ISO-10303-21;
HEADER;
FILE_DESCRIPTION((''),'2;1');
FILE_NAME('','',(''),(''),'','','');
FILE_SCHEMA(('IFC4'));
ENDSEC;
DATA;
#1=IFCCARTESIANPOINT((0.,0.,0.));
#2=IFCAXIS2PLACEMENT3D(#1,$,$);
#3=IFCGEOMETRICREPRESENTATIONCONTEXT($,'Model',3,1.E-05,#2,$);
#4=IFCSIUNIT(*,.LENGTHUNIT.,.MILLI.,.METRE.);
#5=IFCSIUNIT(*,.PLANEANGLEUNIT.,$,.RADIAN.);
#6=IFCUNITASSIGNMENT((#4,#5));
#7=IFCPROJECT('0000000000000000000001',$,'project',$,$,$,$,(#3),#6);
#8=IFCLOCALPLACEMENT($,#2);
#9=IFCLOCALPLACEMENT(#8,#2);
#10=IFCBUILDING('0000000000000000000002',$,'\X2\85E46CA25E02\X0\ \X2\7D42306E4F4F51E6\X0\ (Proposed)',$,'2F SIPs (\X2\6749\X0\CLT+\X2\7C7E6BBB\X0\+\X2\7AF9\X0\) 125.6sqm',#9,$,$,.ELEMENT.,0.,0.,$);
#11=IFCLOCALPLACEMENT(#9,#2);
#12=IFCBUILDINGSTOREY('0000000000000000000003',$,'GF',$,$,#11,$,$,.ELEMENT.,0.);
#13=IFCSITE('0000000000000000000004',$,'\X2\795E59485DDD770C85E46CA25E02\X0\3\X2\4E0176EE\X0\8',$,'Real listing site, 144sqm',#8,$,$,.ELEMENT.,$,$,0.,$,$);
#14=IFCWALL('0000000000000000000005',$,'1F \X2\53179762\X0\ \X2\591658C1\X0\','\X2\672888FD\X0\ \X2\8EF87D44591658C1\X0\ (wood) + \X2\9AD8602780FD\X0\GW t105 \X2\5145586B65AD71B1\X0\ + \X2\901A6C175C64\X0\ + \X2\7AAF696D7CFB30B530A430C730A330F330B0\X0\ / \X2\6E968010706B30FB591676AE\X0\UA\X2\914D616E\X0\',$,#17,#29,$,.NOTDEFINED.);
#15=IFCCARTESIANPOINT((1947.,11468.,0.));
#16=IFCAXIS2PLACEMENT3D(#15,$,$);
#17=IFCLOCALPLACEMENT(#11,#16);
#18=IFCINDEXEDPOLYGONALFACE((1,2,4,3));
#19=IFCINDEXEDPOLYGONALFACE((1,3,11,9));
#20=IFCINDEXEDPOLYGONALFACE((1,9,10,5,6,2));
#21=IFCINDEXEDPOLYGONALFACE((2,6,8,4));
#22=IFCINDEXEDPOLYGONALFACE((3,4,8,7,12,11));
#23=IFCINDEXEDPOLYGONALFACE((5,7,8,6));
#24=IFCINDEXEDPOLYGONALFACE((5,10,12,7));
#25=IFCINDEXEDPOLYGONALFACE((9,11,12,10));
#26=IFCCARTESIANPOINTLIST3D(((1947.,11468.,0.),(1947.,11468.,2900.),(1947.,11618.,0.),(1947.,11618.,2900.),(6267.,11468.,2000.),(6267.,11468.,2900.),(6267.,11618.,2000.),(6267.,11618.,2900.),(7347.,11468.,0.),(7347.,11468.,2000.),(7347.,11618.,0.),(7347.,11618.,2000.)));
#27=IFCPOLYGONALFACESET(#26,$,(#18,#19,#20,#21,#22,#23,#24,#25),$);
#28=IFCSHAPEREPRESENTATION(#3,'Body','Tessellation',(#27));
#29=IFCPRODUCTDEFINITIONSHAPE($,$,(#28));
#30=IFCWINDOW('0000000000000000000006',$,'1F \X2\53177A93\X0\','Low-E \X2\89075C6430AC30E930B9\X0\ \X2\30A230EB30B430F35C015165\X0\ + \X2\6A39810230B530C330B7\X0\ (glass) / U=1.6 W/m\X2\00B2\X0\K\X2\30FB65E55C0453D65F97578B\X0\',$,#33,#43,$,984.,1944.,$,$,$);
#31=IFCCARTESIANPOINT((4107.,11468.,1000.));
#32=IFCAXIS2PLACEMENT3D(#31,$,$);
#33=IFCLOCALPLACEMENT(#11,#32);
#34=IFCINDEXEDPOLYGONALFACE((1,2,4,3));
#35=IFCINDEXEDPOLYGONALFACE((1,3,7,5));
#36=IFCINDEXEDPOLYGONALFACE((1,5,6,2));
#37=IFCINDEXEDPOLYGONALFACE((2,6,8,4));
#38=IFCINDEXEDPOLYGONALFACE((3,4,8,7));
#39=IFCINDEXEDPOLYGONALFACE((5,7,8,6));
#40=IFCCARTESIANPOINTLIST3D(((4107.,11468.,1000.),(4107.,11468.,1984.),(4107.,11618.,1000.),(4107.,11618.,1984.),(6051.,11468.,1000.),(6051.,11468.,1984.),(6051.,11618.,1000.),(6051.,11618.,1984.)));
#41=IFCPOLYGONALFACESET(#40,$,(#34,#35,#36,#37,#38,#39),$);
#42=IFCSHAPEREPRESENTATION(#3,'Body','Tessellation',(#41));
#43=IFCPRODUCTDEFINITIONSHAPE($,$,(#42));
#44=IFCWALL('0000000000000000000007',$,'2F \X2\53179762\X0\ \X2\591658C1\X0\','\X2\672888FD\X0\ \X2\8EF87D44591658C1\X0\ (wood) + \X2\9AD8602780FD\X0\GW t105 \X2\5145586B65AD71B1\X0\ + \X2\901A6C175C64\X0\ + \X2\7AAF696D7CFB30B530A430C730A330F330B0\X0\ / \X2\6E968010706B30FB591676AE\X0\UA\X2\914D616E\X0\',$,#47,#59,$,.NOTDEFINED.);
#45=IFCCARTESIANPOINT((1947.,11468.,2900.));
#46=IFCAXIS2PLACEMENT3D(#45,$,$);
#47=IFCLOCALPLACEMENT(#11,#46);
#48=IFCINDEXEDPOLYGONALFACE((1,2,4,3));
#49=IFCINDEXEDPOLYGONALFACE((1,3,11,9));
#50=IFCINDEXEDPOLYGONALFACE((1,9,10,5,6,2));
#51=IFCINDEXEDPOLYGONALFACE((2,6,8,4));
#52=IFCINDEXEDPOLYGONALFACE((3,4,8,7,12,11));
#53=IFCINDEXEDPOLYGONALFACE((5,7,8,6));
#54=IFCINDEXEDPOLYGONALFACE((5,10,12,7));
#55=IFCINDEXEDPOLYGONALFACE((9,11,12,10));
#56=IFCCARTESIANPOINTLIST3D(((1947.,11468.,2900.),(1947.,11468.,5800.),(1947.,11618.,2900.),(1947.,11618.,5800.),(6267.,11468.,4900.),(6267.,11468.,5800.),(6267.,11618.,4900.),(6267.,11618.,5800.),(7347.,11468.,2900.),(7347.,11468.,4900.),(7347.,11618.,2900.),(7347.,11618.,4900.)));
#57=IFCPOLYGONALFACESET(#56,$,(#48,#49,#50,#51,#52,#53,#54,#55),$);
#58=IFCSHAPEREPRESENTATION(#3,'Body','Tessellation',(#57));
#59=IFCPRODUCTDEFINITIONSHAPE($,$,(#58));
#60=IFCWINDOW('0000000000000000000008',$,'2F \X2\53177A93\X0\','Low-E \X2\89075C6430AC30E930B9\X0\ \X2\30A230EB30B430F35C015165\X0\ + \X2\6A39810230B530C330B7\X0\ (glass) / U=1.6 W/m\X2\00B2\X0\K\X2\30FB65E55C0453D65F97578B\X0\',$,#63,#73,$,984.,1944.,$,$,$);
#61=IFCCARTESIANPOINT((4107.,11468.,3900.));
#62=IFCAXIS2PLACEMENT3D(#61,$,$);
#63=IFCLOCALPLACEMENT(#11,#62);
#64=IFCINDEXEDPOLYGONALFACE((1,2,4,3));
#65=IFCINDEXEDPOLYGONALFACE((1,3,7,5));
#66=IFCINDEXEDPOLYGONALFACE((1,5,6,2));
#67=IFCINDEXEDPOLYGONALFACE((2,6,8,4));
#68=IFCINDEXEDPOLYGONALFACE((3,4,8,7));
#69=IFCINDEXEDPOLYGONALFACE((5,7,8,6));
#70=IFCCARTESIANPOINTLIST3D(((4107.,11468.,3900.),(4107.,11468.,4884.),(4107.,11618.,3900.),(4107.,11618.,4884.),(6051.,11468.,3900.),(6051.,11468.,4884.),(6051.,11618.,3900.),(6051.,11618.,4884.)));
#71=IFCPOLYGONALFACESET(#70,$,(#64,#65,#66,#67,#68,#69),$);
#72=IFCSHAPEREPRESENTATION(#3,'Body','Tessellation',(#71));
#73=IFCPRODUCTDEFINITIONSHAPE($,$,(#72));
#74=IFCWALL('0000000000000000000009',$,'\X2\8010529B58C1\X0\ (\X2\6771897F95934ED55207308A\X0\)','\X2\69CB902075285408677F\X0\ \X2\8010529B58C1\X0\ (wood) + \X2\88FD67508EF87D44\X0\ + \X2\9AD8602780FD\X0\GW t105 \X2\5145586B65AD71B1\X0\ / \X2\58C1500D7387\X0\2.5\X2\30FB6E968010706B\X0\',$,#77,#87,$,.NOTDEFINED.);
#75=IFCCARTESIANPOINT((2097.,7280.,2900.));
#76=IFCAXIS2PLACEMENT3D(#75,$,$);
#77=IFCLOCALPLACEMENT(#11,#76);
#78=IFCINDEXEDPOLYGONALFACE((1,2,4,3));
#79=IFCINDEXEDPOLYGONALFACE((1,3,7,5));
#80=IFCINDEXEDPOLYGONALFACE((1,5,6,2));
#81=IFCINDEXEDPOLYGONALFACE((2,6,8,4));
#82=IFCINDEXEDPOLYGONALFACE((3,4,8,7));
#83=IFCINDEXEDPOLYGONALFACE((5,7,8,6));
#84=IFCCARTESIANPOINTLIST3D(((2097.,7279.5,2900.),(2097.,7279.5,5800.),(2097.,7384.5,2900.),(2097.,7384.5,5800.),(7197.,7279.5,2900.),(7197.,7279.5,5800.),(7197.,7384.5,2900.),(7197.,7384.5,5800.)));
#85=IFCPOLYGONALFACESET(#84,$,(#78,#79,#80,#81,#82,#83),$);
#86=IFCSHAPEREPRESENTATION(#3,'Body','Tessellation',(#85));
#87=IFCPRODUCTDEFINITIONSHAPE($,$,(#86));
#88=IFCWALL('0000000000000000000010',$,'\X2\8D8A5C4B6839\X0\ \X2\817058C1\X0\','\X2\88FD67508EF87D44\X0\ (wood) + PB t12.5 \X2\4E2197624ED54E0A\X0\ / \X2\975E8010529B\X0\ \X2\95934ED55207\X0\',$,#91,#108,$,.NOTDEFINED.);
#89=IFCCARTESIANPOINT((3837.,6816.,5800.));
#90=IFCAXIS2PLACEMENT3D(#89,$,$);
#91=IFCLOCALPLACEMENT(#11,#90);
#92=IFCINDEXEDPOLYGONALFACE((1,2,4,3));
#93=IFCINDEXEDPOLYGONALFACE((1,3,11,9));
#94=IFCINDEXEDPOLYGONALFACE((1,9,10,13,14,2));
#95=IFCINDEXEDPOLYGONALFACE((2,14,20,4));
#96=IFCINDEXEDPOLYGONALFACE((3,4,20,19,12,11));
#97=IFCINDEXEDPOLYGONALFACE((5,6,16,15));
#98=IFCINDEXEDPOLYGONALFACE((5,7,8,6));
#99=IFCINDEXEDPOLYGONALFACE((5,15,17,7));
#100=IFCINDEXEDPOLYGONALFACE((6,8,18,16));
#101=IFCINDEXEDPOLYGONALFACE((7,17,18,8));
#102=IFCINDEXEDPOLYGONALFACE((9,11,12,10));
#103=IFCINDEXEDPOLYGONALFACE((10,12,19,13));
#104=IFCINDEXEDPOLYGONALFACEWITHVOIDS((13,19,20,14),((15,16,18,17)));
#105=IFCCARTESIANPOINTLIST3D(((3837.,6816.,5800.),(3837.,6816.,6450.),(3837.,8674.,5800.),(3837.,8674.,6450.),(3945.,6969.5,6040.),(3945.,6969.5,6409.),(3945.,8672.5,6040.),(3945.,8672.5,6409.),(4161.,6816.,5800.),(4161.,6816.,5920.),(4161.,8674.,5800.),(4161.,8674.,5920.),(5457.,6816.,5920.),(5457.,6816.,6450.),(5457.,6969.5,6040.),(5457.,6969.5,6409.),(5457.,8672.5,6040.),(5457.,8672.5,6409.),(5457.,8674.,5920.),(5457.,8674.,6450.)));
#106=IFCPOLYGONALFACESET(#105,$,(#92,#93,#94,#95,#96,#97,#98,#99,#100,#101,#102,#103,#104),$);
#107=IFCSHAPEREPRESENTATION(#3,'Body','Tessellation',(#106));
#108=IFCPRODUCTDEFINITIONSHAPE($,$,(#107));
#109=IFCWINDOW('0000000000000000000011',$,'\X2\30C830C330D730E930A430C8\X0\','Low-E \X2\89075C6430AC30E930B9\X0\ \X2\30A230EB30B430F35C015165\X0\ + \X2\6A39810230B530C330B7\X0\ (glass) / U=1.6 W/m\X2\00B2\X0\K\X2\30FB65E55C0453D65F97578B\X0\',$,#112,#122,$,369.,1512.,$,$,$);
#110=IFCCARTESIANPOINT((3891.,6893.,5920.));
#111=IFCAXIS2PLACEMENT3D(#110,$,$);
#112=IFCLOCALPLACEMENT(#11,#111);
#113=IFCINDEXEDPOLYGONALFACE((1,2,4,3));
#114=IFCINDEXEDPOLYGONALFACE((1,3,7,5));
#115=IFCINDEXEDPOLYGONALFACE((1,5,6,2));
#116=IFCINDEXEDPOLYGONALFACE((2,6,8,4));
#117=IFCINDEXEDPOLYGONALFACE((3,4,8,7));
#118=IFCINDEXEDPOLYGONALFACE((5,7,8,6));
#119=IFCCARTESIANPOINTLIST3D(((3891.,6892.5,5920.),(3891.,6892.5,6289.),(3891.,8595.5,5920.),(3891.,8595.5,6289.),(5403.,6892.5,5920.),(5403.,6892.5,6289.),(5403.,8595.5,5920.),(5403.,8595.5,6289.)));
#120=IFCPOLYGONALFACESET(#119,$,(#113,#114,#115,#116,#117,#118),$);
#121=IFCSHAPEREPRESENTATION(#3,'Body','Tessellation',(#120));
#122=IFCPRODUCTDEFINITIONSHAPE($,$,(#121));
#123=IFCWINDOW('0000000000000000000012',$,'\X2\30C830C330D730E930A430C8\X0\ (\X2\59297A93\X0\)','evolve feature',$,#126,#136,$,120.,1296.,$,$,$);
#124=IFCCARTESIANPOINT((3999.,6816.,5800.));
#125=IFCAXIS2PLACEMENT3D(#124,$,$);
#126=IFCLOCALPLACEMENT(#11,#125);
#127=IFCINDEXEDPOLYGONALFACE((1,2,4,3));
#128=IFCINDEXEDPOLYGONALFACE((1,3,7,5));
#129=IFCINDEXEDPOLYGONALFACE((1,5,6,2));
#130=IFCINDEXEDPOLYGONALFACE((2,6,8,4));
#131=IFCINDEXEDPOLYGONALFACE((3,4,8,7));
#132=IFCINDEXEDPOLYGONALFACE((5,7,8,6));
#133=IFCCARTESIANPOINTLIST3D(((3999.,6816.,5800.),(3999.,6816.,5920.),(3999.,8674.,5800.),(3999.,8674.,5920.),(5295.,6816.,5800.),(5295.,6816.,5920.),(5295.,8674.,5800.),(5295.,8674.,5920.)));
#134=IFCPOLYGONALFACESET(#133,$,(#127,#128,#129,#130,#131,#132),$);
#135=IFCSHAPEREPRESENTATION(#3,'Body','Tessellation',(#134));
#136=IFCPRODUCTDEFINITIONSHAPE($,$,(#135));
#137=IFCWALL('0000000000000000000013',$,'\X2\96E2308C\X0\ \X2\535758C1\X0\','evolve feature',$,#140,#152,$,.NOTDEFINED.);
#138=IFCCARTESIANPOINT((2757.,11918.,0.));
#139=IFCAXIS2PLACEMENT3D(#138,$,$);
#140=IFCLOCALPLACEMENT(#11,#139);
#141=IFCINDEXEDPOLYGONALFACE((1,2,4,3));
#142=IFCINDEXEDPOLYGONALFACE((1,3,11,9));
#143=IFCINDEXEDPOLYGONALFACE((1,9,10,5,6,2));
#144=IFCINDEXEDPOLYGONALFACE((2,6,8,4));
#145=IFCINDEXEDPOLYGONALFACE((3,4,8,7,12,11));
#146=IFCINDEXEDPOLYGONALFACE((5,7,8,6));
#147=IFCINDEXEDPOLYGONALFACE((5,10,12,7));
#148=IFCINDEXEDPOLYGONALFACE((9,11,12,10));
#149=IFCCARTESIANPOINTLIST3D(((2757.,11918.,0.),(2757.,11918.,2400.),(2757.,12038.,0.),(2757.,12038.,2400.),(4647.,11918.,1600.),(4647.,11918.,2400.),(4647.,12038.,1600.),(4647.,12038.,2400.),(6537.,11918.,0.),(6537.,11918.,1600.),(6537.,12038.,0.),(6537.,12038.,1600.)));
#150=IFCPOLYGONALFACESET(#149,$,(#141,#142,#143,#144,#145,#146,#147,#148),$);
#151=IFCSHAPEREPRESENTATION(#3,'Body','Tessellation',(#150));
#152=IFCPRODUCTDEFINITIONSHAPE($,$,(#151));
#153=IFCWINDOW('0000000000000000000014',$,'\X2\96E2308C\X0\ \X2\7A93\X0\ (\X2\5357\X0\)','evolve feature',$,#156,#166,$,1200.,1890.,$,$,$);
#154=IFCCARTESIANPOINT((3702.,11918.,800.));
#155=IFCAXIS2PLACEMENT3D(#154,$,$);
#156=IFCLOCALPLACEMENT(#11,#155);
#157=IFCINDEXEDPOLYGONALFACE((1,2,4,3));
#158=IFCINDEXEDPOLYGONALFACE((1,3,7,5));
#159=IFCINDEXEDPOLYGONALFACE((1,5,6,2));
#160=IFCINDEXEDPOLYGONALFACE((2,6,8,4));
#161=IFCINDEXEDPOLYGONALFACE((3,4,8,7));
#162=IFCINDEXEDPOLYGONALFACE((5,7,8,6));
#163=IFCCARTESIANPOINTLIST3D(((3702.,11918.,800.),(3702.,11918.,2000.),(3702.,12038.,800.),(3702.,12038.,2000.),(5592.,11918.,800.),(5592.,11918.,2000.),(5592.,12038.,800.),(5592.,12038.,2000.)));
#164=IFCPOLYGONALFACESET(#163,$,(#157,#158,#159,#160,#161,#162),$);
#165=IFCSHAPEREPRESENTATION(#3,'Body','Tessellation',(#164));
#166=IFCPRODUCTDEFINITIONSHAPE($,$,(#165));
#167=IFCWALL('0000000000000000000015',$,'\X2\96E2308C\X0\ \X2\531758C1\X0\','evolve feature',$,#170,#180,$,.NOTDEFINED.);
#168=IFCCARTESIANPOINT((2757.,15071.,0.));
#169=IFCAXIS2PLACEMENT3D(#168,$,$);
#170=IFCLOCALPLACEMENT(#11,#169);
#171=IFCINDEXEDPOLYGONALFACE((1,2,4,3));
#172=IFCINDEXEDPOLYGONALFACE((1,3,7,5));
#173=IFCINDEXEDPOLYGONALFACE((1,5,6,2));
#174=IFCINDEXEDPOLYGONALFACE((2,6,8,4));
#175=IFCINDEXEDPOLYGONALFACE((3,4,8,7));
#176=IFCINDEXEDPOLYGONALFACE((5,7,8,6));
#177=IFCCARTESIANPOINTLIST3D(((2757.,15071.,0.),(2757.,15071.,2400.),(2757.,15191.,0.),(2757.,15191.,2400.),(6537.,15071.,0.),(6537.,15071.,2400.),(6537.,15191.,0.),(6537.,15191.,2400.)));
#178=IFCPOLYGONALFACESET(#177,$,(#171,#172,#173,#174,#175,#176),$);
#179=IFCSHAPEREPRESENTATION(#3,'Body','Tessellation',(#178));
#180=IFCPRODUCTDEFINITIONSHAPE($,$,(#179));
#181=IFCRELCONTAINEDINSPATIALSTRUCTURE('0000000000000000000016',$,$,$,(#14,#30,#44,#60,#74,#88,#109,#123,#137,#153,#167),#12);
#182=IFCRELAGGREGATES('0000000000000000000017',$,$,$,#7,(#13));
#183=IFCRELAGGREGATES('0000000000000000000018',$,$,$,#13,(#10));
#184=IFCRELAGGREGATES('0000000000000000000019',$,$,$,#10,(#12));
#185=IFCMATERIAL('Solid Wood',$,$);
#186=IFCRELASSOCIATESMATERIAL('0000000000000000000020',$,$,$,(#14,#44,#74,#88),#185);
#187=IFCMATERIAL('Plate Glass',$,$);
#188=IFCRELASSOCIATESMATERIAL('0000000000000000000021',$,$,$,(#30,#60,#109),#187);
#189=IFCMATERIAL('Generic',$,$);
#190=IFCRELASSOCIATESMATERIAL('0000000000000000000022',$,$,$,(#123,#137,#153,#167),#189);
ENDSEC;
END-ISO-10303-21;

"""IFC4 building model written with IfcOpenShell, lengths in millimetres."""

from ifc_helpers import new_model, si_unit, frame, frame_2d, origin, place, context, project, spatial, rectangle, extrude, material, element, fill, save


model = new_model("IFC4")

# Units and contexts
model_context = context("Model", 3, precision=1e-05, world=origin())
ifc_project = project(units=[si_unit("LENGTHUNIT", "METRE", prefix="MILLI"), si_unit("PLANEANGLEUNIT", "RADIAN")], contexts=[model_context])

# Site, building, storey
site_placement = place(None, origin())
site = spatial("IfcSite", under=ifc_project, at=site_placement, Name="神奈川県藤沢市3丁目8", ObjectType="Real listing site, 144sqm", CompositionType="ELEMENT", RefElevation=0.0)
building_placement = place(site_placement, origin())
building = spatial("IfcBuilding", under=site, at=building_placement, Name="藤沢市 終の住処 (Proposed)", ObjectType="2F SIPs (杉CLT+籾殻+竹) 125.6sqm", CompositionType="ELEMENT", ElevationOfRefHeight=0.0, ElevationOfTerrain=0.0)
storey_placement = place(building_placement, origin())
storey = spatial("IfcBuildingStorey", under=building, at=storey_placement, Name="GF", CompositionType="ELEMENT", Elevation=0.0)

# Shared definitions
ifc_material_1 = material(Name="Generic")

# Wall, opening, window
ifc_material_2 = material(Name="Solid Wood")
wall_1_placement = place(storey_placement, frame((1947.0, 11468.0, 0.0)))
wall_1 = element("IfcWall", 1, at=wall_1_placement, inside=storey, material=ifc_material_2, Name="1F 北面 外壁", Description="木製 軸組外壁 (wood) + 高性能GW t105 充填断熱 + 通気層 + 窯業系サイディング / 準耐火・外皮UA配慮", PredefinedType="NOTDEFINED", context=model_context, shape_type="SweptSolid", body=[
    extrude(rectangle(XDim=5400.0, YDim=150.0, at=frame_2d((2700.0, 75.0))), frame((1947.0, 11468.0, 0.0)), (0.0, 0.0, 1.0), 2900.0),
])
opening_1_placement = place(storey_placement, frame((4107.0, 11468.0, 1000.0)))
opening_1 = element("IfcOpeningElement", 2, at=opening_1_placement, cuts=wall_1, PredefinedType="NOTDEFINED", context=model_context, shape_type="SweptSolid", body=[
    extrude(rectangle(XDim=1944.0, YDim=150.0, at=frame_2d((972.0, 75.0))), frame((4107.0, 11468.0, 1000.0)), (0.0, 0.0, 1.0), 984.0),
])
ifc_material_3 = material(Name="Plate Glass")
window_1_placement = place(storey_placement, frame((4107.0, 11468.0, 1000.0)))
window_1 = element("IfcWindow", 3, at=window_1_placement, inside=storey, material=ifc_material_3, Name="1F 北窓", Description="Low-E 複層ガラス アルゴン封入 + 樹脂サッシ (glass) / U=1.6 W/m²K・日射取得型", OverallHeight=984.0, OverallWidth=1944.0, context=model_context, shape_type="SweptSolid", body=[
    extrude(rectangle(XDim=1944.0, YDim=150.0, at=frame_2d((972.0, 75.0))), frame((4107.0, 11468.0, 1000.0)), (0.0, 0.0, 1.0), 984.0),
])
fill(opening_1, window_1)

# Wall, opening, window
wall_2_placement = place(storey_placement, frame((1947.0, 11468.0, 2900.0)))
wall_2 = element("IfcWall", 4, at=wall_2_placement, inside=storey, material=ifc_material_2, Name="2F 北面 外壁", Description="木製 軸組外壁 (wood) + 高性能GW t105 充填断熱 + 通気層 + 窯業系サイディング / 準耐火・外皮UA配慮", PredefinedType="NOTDEFINED", context=model_context, shape_type="SweptSolid", body=[
    extrude(rectangle(XDim=5400.0, YDim=150.0, at=frame_2d((2700.0, 75.0))), frame((1947.0, 11468.0, 2900.0)), (0.0, 0.0, 1.0), 2900.0),
])
opening_2_placement = place(storey_placement, frame((4107.0, 11468.0, 3900.0)))
opening_2 = element("IfcOpeningElement", 5, at=opening_2_placement, cuts=wall_2, PredefinedType="NOTDEFINED", context=model_context, shape_type="SweptSolid", body=[
    extrude(rectangle(XDim=1944.0, YDim=150.0, at=frame_2d((972.0, 75.0))), frame((4107.0, 11468.0, 3900.0)), (0.0, 0.0, 1.0), 984.0),
])
window_2_placement = place(storey_placement, frame((4107.0, 11468.0, 3900.0)))
window_2 = element("IfcWindow", 6, at=window_2_placement, inside=storey, material=ifc_material_3, Name="2F 北窓", Description="Low-E 複層ガラス アルゴン封入 + 樹脂サッシ (glass) / U=1.6 W/m²K・日射取得型", OverallHeight=984.0, OverallWidth=1944.0, context=model_context, shape_type="SweptSolid", body=[
    extrude(rectangle(XDim=1944.0, YDim=150.0, at=frame_2d((972.0, 75.0))), frame((4107.0, 11468.0, 3900.0)), (0.0, 0.0, 1.0), 984.0),
])
fill(opening_2, window_2)

# Wall
wall_3_placement = place(storey_placement, frame((2097.0, 7280.0, 2900.0)))
element("IfcWall", 7, at=wall_3_placement, inside=storey, material=ifc_material_2, Name="耐力壁 (東西間仕切り)", Description="構造用合板 耐力壁 (wood) + 製材軸組 + 高性能GW t105 充填断熱 / 壁倍率2.5・準耐火", PredefinedType="NOTDEFINED", context=model_context, shape_type="SweptSolid", body=[
    extrude(rectangle(XDim=5100.0, YDim=105.0, at=frame_2d((2550.0, 52.0))), frame((2097.0, 7280.0, 2900.0)), (0.0, 0.0, 1.0), 2900.0),
])

# Wall, openings, windows
wall_4_placement = place(storey_placement, frame((3837.0, 6816.0, 5800.0)))
wall_4 = element("IfcWall", 8, at=wall_4_placement, inside=storey, material=ifc_material_2, Name="越屋根 腰壁", Description="製材軸組 (wood) + PB t12.5 両面仕上 / 非耐力 間仕切", PredefinedType="NOTDEFINED", context=model_context, shape_type="SweptSolid", body=[
    extrude(rectangle(XDim=1620.0, YDim=1858.0, at=frame_2d((810.0, 929.0))), frame((3837.0, 6816.0, 5800.0)), (0.0, 0.0, 1.0), 650.0),
])
opening_3_placement = place(storey_placement, frame((3891.0, 6893.0, 5920.0)))
opening_3 = element("IfcOpeningElement", 9, at=opening_3_placement, cuts=wall_4, PredefinedType="NOTDEFINED", context=model_context, shape_type="SweptSolid", body=[
    extrude(rectangle(XDim=1512.0, YDim=1703.0, at=frame_2d((756.0, 851.0))), frame((3891.0, 6893.0, 5920.0)), (0.0, 0.0, 1.0), 369.0),
])
opening_4_placement = place(storey_placement, frame((3999.0, 6816.0, 5800.0)))
opening_4 = element("IfcOpeningElement", 10, at=opening_4_placement, cuts=wall_4, PredefinedType="NOTDEFINED", context=model_context, shape_type="SweptSolid", body=[
    extrude(rectangle(XDim=1296.0, YDim=1858.0, at=frame_2d((648.0, 929.0))), frame((3999.0, 6816.0, 5800.0)), (0.0, 0.0, 1.0), 120.0),
])
window_3_placement = place(storey_placement, frame((3891.0, 6893.0, 5920.0)))
window_3 = element("IfcWindow", 11, at=window_3_placement, inside=storey, material=ifc_material_3, Name="トップライト", Description="Low-E 複層ガラス アルゴン封入 + 樹脂サッシ (glass) / U=1.6 W/m²K・日射取得型", OverallHeight=369.0, OverallWidth=1512.0, context=model_context, shape_type="SweptSolid", body=[
    extrude(rectangle(XDim=1512.0, YDim=1703.0, at=frame_2d((756.0, 851.0))), frame((3891.0, 6893.0, 5920.0)), (0.0, 0.0, 1.0), 369.0),
])
fill(opening_3, window_3)
window_4_placement = place(storey_placement, frame((3999.0, 6816.0, 5800.0)))
window_4 = element("IfcWindow", 12, at=window_4_placement, inside=storey, material=ifc_material_1, Name="トップライト (天窓)", Description="evolve feature", OverallHeight=120.0, OverallWidth=1296.0, context=model_context, shape_type="SweptSolid", body=[
    extrude(rectangle(XDim=1296.0, YDim=1858.0, at=frame_2d((648.0, 929.0))), frame((3999.0, 6816.0, 5800.0)), (0.0, 0.0, 1.0), 120.0),
])
fill(opening_4, window_4)

# Wall, opening, window
wall_5_placement = place(storey_placement, frame((2757.0, 11918.0, 0.0)))
wall_5 = element("IfcWall", 13, at=wall_5_placement, inside=storey, material=ifc_material_1, Name="離れ 南壁", Description="evolve feature", PredefinedType="NOTDEFINED", context=model_context, shape_type="SweptSolid", body=[
    extrude(rectangle(XDim=3780.0, YDim=120.0, at=frame_2d((1890.0, 60.0))), frame((2757.0, 11918.0, 0.0)), (0.0, 0.0, 1.0), 2400.0),
])
opening_5_placement = place(storey_placement, frame((3702.0, 11918.0, 800.0)))
opening_5 = element("IfcOpeningElement", 14, at=opening_5_placement, cuts=wall_5, PredefinedType="NOTDEFINED", context=model_context, shape_type="SweptSolid", body=[
    extrude(rectangle(XDim=1890.0, YDim=120.0, at=frame_2d((945.0, 60.0))), frame((3702.0, 11918.0, 800.0)), (0.0, 0.0, 1.0), 1200.0),
])
window_5_placement = place(storey_placement, frame((3702.0, 11918.0, 800.0)))
window_5 = element("IfcWindow", 15, at=window_5_placement, inside=storey, material=ifc_material_1, Name="離れ 窓 (南)", Description="evolve feature", OverallHeight=1200.0, OverallWidth=1890.0, context=model_context, shape_type="SweptSolid", body=[
    extrude(rectangle(XDim=1890.0, YDim=120.0, at=frame_2d((945.0, 60.0))), frame((3702.0, 11918.0, 800.0)), (0.0, 0.0, 1.0), 1200.0),
])
fill(opening_5, window_5)

# Wall
wall_6_placement = place(storey_placement, frame((2757.0, 15071.0, 0.0)))
element("IfcWall", 16, at=wall_6_placement, inside=storey, material=ifc_material_1, Name="離れ 北壁", Description="evolve feature", PredefinedType="NOTDEFINED", context=model_context, shape_type="SweptSolid", body=[
    extrude(rectangle(XDim=3780.0, YDim=120.0, at=frame_2d((1890.0, 60.0))), frame((2757.0, 15071.0, 0.0)), (0.0, 0.0, 1.0), 2400.0),
])

save(model, "model.ifc")
